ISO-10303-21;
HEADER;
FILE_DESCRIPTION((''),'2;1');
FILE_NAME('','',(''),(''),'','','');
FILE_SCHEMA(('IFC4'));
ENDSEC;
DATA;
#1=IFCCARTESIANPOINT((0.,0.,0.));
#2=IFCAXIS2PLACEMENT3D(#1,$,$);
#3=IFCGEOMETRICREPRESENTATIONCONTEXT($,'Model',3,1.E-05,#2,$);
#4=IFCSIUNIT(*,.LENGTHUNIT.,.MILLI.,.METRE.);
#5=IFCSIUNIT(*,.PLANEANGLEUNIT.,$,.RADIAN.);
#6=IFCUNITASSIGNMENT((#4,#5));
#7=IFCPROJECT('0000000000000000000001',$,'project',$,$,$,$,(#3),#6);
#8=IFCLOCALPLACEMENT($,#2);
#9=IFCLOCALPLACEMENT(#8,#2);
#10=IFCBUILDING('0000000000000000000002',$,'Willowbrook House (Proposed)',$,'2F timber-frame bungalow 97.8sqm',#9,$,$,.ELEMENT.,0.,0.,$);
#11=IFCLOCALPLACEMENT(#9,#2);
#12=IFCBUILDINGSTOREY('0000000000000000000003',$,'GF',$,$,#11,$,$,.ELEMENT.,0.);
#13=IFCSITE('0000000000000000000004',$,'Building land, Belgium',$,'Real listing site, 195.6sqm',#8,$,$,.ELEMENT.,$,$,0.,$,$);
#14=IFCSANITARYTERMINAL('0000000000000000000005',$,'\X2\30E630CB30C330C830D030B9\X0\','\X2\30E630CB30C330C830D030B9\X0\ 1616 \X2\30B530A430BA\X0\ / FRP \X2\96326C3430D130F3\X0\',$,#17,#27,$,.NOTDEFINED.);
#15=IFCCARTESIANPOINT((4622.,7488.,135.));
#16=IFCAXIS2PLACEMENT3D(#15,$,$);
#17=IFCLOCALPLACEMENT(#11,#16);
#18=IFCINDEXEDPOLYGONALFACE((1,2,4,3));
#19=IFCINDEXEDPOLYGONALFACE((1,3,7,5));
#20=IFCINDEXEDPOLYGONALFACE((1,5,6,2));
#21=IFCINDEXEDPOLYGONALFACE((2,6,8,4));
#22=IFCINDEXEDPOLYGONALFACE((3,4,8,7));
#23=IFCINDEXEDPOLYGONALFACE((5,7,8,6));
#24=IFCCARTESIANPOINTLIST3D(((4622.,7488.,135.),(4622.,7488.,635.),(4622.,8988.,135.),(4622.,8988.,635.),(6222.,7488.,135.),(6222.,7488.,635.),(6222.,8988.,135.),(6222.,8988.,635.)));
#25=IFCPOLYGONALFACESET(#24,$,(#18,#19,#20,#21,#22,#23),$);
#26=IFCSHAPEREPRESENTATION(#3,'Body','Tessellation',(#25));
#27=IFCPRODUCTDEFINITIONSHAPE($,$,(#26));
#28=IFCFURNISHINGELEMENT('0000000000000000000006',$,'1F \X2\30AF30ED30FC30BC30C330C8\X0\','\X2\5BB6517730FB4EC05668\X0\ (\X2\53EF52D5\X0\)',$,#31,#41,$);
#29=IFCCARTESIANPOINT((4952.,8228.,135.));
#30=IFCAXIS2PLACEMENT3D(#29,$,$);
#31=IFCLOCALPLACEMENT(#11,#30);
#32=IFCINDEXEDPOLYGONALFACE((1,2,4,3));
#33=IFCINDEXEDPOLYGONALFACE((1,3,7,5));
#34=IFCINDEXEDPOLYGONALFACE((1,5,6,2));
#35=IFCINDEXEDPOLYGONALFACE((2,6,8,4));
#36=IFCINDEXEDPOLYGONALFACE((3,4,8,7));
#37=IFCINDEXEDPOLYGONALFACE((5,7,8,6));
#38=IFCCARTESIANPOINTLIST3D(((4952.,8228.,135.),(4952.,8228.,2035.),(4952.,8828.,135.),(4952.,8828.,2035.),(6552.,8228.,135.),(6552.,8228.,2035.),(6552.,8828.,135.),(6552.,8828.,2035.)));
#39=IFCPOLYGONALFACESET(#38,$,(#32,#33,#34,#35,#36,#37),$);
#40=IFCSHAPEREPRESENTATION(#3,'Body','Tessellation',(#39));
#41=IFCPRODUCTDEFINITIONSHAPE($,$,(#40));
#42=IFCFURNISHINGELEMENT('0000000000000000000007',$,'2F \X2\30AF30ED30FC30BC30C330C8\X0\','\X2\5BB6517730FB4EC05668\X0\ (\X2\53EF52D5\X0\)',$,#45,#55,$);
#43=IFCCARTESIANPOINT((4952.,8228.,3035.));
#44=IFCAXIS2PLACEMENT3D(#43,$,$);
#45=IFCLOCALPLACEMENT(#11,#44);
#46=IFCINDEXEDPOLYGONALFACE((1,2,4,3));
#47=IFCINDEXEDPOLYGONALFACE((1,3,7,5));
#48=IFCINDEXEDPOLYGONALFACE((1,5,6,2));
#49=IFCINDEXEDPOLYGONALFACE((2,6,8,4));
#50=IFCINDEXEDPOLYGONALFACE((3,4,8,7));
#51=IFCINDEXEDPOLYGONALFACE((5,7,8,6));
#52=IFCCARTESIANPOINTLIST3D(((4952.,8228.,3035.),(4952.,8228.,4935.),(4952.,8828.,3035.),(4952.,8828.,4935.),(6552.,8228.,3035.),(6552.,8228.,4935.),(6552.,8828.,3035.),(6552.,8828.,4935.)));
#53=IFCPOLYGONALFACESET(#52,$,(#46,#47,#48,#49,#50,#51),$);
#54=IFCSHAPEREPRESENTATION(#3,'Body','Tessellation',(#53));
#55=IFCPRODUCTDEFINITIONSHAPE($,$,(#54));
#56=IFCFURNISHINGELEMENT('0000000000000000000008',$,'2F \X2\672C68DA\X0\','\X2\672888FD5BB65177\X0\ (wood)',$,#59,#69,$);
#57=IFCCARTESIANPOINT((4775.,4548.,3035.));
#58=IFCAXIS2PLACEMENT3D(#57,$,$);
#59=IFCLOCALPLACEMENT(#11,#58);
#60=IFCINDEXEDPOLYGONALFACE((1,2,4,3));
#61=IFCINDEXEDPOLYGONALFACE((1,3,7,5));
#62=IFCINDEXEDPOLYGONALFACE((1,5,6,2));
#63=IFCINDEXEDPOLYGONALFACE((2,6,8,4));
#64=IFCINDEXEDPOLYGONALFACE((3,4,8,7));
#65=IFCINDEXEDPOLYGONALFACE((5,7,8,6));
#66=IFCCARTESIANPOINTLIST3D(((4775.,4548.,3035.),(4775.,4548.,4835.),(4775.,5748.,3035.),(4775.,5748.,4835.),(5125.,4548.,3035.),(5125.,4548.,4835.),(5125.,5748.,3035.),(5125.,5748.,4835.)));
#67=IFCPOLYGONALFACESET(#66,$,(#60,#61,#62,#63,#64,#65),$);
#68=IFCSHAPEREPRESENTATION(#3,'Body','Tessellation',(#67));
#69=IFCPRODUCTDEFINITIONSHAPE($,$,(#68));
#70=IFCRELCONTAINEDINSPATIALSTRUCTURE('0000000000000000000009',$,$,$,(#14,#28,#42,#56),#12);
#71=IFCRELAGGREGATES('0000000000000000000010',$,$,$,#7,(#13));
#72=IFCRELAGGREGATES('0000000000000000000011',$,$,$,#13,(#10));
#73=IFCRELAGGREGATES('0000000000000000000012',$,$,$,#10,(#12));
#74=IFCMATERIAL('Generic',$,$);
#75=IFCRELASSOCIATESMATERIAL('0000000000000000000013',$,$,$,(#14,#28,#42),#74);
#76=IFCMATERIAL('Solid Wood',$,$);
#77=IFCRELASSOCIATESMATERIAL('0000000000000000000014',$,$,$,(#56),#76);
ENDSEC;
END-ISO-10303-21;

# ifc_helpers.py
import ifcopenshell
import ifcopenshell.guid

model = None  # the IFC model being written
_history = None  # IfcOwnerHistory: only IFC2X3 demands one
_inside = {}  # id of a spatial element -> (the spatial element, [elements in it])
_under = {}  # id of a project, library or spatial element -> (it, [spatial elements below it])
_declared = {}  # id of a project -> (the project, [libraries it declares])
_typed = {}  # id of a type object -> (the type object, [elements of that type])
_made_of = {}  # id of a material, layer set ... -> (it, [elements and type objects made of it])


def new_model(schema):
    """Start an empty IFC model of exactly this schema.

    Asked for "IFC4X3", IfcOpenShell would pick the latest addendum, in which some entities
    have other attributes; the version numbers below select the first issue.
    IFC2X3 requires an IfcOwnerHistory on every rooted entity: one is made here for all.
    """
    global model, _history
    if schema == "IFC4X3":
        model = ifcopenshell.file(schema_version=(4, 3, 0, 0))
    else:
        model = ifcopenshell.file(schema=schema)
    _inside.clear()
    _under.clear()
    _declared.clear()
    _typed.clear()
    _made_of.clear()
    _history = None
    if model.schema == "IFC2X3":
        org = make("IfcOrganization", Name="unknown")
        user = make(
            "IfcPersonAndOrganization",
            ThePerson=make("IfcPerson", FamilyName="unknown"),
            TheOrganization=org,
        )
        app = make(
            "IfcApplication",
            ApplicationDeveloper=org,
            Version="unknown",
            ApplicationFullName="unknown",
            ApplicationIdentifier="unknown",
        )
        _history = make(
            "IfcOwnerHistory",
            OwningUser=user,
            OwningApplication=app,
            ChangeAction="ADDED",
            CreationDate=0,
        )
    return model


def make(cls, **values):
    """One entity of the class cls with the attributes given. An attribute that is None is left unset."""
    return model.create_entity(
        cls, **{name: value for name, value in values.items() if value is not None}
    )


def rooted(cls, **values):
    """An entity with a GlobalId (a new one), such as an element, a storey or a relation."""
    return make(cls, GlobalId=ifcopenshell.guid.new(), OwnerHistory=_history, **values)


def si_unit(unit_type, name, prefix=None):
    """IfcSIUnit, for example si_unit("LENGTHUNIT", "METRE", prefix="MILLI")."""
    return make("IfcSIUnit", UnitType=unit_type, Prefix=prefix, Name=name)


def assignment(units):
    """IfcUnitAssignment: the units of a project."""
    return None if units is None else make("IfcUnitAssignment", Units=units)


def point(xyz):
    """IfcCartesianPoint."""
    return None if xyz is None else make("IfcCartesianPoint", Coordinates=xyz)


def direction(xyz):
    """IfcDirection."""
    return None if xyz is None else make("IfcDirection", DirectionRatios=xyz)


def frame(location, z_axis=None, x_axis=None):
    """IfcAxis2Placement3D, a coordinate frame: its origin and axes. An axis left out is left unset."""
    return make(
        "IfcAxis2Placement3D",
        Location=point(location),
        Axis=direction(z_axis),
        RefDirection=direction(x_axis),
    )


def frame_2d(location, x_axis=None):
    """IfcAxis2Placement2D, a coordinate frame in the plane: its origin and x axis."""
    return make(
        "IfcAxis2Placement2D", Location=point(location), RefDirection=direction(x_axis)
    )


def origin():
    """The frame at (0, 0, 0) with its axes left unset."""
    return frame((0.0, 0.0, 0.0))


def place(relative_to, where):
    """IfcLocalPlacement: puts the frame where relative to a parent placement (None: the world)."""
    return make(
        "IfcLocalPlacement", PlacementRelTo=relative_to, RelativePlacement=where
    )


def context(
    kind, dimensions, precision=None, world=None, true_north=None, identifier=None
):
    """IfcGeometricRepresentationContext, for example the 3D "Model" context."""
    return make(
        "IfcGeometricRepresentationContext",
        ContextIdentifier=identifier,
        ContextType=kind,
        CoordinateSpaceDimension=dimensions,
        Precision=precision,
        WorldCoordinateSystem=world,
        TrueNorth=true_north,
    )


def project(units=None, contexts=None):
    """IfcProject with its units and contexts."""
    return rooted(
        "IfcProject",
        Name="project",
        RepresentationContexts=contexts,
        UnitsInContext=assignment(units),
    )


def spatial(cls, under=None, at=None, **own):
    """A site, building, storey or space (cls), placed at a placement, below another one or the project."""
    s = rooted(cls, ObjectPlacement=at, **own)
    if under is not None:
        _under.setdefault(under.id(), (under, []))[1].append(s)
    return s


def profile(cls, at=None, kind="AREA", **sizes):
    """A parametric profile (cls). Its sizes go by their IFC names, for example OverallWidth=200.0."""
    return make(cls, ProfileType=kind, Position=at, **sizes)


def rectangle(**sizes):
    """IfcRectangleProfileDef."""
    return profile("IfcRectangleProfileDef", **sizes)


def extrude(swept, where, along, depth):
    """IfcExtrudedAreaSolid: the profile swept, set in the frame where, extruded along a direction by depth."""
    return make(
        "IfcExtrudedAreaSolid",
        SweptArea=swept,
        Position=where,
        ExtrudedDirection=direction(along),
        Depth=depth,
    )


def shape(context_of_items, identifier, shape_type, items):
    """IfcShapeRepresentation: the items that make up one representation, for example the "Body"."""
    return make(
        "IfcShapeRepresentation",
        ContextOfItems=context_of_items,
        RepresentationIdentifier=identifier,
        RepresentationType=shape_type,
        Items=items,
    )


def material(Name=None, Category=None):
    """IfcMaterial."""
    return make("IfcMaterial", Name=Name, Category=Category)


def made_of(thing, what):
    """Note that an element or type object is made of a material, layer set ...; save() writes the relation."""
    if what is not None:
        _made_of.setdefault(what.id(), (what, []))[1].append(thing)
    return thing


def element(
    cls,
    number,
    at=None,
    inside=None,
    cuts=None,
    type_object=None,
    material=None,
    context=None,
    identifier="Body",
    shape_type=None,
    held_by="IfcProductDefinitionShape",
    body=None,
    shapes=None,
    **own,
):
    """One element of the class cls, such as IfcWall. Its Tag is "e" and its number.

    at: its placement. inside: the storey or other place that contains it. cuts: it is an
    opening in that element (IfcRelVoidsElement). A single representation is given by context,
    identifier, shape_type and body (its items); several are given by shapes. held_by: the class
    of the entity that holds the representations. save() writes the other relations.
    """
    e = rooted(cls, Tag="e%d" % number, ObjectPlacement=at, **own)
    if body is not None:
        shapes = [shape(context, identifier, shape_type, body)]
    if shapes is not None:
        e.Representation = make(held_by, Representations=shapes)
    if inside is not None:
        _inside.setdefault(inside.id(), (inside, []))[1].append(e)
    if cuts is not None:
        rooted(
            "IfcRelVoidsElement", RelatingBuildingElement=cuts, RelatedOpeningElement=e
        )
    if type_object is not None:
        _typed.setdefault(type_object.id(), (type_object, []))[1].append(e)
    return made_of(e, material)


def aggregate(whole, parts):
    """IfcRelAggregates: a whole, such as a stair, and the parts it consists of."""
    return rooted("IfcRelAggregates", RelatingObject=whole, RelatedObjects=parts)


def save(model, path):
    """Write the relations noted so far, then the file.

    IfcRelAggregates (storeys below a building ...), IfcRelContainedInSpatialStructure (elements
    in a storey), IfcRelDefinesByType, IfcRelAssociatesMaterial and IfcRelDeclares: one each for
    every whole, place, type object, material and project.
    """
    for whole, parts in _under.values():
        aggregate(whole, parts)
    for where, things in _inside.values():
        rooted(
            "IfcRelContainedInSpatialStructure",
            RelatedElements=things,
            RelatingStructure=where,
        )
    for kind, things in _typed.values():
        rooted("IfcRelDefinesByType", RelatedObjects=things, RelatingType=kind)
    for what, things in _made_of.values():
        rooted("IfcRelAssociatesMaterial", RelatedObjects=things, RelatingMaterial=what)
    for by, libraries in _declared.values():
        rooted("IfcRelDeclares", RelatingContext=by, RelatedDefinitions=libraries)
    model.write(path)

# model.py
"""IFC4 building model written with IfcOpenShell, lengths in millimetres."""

from ifc_helpers import new_model, si_unit, frame, frame_2d, origin, place, context, project, spatial, rectangle, extrude, material, element, save


model = new_model("IFC4")

# Units and contexts
model_context = context("Model", 3, precision=1e-05, world=origin())
ifc_project = project(units=[si_unit("LENGTHUNIT", "METRE", prefix="MILLI"), si_unit("PLANEANGLEUNIT", "RADIAN")], contexts=[model_context])

# Site, building, storey
site_placement = place(None, origin())
site = spatial("IfcSite", under=ifc_project, at=site_placement, Name="Building land, Belgium", ObjectType="Real listing site, 195.6sqm", CompositionType="ELEMENT", RefElevation=0.0)
building_placement = place(site_placement, origin())
building = spatial("IfcBuilding", under=site, at=building_placement, Name="Willowbrook House (Proposed)", ObjectType="2F timber-frame bungalow 97.8sqm", CompositionType="ELEMENT", ElevationOfRefHeight=0.0, ElevationOfTerrain=0.0)
storey_placement = place(building_placement, origin())
storey = spatial("IfcBuildingStorey", under=building, at=storey_placement, Name="GF", CompositionType="ELEMENT", Elevation=0.0)

# Shared definitions
ifc_material_1 = material(Name="Solid Wood")

# Shared definitions
ifc_material_2 = material(Name="Generic")

# Sanitary terminal
sanitary_terminal_placement = place(storey_placement, frame((4622.0, 7488.0, 135.0)))
element("IfcSanitaryTerminal", 1, at=sanitary_terminal_placement, inside=storey, material=ifc_material_2, Name="ユニットバス", Description="ユニットバス 1616 サイズ / FRP 防水パン", PredefinedType="NOTDEFINED", context=model_context, shape_type="SweptSolid", body=[
    extrude(rectangle(XDim=1600.0, YDim=1500.0, at=frame_2d((800.0, 750.0))), frame((4622.0, 7488.0, 135.0)), (0.0, 0.0, 1.0), 500.0),
])

# Furnishing elements
furnishing_1_placement = place(storey_placement, frame((4952.0, 8228.0, 135.0)))
element("IfcFurnishingElement", 2, at=furnishing_1_placement, inside=storey, material=ifc_material_2, Name="1F クローゼット", Description="家具・什器 (可動)", context=model_context, shape_type="SweptSolid", body=[
    extrude(rectangle(XDim=1600.0, YDim=600.0, at=frame_2d((800.0, 300.0))), frame((4952.0, 8228.0, 135.0)), (0.0, 0.0, 1.0), 1900.0),
])
furnishing_2_placement = place(storey_placement, frame((4952.0, 8228.0, 3035.0)))
element("IfcFurnishingElement", 3, at=furnishing_2_placement, inside=storey, material=ifc_material_2, Name="2F クローゼット", Description="家具・什器 (可動)", context=model_context, shape_type="SweptSolid", body=[
    extrude(rectangle(XDim=1600.0, YDim=600.0, at=frame_2d((800.0, 300.0))), frame((4952.0, 8228.0, 3035.0)), (0.0, 0.0, 1.0), 1900.0),
])
furnishing_3_placement = place(storey_placement, frame((4775.0, 4548.0, 3035.0)))
element("IfcFurnishingElement", 4, at=furnishing_3_placement, inside=storey, material=ifc_material_1, Name="2F 本棚", Description="木製家具 (wood)", context=model_context, shape_type="SweptSolid", body=[
    extrude(rectangle(XDim=350.0, YDim=1200.0, at=frame_2d((175.0, 600.0))), frame((4775.0, 4548.0, 3035.0)), (0.0, 0.0, 1.0), 1800.0),
])

save(model, "model.ifc")
